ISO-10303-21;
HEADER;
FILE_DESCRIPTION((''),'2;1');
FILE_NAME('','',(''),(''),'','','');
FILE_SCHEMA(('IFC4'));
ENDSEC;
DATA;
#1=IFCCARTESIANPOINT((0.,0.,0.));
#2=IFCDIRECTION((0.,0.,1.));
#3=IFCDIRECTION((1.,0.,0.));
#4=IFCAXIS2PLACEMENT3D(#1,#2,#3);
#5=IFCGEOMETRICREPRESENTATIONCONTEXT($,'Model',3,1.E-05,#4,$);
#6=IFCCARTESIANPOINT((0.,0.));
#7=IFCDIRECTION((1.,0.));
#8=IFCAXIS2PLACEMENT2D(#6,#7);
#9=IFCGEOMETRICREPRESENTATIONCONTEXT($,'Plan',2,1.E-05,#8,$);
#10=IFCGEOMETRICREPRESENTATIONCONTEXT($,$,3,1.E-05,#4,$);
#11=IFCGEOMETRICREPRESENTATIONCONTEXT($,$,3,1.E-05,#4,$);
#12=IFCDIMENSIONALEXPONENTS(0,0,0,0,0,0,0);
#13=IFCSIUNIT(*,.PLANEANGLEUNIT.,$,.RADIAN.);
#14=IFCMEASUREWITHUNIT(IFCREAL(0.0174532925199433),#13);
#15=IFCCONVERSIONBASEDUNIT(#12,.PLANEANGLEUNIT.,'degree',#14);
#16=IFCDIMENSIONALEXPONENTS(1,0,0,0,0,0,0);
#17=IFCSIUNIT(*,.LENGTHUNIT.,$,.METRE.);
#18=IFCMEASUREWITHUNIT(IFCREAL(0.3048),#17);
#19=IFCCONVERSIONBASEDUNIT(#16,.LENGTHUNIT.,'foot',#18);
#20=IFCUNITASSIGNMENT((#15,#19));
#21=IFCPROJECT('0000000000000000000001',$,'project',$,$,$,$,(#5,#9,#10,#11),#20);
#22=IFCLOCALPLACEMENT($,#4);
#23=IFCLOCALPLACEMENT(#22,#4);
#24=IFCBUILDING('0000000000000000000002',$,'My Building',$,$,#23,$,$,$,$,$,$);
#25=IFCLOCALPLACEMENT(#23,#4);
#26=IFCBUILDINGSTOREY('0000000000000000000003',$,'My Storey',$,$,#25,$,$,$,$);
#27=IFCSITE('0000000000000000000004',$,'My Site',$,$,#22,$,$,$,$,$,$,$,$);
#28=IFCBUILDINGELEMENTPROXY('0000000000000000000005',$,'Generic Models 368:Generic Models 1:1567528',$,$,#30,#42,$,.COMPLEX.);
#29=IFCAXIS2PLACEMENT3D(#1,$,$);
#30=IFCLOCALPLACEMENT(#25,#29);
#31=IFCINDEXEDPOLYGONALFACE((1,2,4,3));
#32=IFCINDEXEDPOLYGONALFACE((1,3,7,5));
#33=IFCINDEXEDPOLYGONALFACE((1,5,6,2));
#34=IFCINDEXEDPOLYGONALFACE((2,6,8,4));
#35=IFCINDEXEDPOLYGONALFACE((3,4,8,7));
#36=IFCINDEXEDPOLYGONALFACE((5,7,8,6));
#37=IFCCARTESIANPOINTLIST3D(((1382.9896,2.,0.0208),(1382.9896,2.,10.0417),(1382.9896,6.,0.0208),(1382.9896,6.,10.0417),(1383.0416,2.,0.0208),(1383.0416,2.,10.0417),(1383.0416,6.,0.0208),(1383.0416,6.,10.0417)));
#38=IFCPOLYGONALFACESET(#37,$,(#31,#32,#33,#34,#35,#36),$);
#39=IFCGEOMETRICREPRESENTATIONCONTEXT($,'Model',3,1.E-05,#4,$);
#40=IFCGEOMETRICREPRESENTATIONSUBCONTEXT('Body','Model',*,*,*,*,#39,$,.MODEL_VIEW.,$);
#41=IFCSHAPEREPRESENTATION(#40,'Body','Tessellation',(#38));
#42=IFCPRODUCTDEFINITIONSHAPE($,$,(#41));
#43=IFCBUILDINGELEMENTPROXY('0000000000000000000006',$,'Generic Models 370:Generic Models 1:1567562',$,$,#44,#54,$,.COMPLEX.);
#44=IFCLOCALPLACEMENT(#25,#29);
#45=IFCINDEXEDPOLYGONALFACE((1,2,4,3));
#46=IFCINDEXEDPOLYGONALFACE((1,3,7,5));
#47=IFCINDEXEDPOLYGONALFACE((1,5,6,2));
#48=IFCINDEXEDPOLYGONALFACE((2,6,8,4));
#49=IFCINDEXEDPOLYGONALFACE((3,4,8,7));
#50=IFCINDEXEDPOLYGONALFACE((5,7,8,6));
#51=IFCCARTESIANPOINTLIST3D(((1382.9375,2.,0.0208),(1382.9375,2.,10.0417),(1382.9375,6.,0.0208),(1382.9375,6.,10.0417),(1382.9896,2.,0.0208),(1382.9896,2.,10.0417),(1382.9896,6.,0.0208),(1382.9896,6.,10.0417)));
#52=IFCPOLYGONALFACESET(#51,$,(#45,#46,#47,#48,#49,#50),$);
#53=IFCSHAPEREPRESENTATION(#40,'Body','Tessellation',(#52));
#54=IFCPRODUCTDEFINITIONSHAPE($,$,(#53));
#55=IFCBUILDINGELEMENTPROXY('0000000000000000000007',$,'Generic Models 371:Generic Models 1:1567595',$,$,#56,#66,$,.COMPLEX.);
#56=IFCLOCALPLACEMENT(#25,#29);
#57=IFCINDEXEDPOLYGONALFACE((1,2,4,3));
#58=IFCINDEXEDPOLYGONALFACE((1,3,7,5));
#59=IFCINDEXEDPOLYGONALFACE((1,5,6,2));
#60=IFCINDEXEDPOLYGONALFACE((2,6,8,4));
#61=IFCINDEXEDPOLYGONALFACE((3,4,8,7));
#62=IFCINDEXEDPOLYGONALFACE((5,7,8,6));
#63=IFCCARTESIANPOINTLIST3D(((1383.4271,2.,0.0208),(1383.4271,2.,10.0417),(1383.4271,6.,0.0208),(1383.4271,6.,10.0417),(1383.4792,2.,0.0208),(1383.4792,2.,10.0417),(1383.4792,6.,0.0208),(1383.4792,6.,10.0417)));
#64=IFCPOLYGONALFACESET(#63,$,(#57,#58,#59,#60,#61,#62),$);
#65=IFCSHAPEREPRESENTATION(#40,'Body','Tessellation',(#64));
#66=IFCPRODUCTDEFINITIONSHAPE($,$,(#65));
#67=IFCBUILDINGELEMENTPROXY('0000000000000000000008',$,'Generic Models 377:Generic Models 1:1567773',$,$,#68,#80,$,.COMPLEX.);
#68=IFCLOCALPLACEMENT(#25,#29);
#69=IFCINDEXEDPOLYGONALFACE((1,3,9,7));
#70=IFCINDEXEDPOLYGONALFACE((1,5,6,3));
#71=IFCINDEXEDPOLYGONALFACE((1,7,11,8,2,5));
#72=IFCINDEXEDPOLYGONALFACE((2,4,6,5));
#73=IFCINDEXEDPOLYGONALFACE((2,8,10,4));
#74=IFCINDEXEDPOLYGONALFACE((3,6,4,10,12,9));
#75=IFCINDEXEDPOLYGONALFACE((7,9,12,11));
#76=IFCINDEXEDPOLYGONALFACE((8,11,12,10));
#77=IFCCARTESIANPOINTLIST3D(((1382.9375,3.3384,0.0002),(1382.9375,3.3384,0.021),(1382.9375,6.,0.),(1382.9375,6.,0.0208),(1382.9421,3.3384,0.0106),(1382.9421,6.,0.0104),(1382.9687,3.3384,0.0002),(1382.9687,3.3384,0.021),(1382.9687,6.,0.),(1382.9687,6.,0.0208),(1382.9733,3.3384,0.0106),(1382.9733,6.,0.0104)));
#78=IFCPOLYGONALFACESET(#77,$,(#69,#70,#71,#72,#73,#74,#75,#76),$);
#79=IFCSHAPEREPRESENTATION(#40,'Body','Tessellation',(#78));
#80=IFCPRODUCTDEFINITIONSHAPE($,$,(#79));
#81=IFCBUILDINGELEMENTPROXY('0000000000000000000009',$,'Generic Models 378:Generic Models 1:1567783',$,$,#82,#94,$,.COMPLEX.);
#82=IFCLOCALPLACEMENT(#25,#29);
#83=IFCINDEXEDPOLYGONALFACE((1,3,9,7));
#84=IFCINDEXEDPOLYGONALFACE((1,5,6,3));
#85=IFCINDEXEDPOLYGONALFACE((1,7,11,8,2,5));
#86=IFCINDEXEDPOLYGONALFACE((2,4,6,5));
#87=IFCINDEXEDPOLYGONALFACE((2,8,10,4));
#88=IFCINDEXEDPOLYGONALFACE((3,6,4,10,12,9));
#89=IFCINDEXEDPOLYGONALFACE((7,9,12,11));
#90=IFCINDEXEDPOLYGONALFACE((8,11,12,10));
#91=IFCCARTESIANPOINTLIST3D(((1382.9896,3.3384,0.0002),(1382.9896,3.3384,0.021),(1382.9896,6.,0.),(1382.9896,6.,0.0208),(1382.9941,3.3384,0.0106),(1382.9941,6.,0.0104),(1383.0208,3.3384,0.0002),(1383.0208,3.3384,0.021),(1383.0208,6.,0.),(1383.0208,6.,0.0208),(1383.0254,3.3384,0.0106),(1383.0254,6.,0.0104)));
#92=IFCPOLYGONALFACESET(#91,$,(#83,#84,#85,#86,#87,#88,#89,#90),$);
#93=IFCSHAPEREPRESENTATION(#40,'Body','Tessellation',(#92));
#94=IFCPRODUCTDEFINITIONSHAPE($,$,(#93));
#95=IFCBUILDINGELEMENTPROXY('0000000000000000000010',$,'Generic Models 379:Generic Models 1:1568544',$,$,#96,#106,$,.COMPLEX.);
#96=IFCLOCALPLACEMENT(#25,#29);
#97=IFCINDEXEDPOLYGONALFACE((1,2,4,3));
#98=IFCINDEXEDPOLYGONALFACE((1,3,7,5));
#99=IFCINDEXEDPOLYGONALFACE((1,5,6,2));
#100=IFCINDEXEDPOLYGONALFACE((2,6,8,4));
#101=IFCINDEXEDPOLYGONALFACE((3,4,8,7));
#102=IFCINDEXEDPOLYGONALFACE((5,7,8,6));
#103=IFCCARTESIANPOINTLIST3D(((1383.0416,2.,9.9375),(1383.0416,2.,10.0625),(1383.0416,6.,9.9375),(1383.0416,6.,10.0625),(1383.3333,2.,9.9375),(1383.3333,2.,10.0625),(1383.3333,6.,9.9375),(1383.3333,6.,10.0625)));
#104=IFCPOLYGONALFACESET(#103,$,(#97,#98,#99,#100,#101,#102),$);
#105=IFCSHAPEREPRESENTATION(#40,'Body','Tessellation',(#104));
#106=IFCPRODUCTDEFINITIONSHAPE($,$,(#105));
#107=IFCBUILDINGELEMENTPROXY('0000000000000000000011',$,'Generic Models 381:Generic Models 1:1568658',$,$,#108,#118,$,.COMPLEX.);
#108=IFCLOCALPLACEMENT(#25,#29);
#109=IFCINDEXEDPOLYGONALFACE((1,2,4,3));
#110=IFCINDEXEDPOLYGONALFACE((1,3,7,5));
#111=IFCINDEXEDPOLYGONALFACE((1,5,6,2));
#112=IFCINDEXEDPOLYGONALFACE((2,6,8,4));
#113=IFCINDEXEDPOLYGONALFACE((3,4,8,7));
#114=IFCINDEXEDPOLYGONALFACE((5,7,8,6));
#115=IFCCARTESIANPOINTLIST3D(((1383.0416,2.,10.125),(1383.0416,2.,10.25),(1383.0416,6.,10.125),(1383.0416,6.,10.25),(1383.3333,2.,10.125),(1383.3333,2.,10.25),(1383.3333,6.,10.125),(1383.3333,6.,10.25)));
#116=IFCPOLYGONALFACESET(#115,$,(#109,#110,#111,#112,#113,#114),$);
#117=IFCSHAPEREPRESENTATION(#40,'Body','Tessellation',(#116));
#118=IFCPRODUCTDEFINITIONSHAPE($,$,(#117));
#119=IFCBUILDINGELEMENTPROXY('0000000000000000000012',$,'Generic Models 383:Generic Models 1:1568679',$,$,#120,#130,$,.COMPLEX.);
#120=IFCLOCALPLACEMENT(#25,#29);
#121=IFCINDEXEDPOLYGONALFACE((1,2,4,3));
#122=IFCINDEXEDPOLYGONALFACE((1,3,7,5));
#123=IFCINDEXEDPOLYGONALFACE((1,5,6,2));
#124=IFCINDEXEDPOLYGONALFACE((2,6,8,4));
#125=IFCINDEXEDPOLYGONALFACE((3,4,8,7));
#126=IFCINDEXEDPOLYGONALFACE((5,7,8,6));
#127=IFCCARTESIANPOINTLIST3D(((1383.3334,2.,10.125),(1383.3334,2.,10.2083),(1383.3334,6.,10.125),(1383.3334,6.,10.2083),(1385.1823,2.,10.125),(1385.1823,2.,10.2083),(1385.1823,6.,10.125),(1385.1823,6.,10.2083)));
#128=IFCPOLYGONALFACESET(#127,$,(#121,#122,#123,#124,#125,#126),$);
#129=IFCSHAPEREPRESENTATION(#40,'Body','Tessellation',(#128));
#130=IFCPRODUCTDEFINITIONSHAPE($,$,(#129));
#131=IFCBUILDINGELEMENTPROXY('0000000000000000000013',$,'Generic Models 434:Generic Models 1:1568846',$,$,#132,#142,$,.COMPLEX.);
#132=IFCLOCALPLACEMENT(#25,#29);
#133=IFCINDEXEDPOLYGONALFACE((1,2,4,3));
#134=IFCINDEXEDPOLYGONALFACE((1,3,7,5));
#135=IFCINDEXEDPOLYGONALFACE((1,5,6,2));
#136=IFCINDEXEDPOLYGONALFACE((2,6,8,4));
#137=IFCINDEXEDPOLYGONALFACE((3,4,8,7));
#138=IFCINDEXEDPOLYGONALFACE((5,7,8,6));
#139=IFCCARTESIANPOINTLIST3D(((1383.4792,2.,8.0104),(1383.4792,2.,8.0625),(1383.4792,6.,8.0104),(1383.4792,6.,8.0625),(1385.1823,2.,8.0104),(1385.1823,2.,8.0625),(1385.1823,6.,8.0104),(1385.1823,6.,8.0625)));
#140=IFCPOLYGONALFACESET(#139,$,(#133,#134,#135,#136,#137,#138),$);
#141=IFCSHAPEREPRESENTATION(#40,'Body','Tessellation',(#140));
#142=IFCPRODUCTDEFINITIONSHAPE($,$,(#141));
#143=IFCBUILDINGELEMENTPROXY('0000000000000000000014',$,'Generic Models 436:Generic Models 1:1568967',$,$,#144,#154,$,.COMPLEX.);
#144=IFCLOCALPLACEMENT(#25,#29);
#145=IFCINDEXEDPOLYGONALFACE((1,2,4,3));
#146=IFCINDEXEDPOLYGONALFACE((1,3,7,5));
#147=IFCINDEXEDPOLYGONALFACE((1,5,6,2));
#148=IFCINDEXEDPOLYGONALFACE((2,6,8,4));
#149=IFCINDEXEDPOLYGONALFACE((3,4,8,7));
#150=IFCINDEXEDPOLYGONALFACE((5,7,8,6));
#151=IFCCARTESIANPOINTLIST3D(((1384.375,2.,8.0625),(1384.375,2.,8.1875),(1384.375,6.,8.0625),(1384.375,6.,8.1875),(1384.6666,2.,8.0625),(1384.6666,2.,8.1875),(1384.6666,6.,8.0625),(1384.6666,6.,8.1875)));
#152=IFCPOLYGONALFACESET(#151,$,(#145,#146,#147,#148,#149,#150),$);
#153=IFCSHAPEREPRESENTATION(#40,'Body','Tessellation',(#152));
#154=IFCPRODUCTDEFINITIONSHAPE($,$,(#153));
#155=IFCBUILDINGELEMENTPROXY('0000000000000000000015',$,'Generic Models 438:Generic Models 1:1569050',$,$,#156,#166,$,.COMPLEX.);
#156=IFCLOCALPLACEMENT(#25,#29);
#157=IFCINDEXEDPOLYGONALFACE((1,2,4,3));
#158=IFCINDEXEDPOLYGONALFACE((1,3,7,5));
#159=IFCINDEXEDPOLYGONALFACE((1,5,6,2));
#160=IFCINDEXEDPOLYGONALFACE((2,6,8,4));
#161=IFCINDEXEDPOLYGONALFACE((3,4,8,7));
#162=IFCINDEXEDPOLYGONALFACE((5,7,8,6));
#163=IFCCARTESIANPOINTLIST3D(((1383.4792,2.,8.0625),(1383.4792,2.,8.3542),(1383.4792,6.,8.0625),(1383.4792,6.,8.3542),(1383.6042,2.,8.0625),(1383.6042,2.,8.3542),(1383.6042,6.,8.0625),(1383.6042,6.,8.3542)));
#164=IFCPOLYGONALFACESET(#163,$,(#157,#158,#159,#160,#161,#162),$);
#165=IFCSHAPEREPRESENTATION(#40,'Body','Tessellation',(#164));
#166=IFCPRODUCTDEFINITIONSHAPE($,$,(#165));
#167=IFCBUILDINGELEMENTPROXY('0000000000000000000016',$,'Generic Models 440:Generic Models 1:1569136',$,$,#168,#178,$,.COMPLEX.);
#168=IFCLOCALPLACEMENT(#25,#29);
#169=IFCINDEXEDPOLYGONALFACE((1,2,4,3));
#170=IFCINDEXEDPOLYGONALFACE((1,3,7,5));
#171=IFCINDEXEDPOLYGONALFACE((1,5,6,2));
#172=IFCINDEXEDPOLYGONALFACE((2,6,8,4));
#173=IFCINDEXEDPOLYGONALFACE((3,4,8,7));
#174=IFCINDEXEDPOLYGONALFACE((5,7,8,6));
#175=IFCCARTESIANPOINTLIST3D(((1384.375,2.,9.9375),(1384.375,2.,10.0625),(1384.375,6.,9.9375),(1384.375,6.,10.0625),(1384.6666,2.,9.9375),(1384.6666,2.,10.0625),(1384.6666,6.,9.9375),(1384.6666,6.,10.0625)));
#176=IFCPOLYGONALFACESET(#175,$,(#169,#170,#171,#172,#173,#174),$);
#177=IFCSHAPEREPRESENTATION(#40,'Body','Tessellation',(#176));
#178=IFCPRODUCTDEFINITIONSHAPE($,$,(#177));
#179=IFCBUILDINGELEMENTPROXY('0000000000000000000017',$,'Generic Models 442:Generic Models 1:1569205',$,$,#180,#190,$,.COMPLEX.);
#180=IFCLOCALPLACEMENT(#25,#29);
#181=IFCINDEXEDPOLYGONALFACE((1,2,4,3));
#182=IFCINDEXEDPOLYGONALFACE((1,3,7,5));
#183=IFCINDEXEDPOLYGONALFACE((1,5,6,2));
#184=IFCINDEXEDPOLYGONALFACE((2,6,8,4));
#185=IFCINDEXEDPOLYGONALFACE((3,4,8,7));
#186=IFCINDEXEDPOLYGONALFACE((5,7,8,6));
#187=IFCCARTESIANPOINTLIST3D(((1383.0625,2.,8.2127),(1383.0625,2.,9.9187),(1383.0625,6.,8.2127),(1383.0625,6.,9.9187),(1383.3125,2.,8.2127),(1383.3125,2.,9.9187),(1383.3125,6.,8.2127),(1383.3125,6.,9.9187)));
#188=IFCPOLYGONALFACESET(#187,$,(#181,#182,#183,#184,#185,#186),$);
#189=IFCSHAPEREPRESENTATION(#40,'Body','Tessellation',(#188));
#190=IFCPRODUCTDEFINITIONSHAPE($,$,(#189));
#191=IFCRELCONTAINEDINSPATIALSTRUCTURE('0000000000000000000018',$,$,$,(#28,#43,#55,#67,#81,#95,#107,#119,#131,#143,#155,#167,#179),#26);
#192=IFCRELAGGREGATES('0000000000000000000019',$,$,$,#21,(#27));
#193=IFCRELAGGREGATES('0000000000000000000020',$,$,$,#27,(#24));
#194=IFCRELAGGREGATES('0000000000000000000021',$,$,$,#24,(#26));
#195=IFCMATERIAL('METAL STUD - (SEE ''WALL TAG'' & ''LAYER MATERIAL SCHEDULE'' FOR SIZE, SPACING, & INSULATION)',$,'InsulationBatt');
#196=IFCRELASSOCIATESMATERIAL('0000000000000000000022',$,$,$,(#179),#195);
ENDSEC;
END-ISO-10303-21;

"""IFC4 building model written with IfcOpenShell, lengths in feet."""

from ifc_helpers import new_model, entity, si_unit, converted_unit, frame, origin_with_axes, origin_2d_with_axis, place, context, subcontext, project, spatial, polyline, outline, extrude, material, element, save


model = new_model("IFC4")

# Units and contexts
model_context_1 = context("Model", 3, precision=1e-05, world=origin_with_axes())
plan_context = context("Plan", 2, precision=1e-05, world=origin_2d_with_axis())
model_context_2 = context("Model", 3, precision=1e-05, world=origin_with_axes())
context_of_model_1 = context(None, 3, precision=1e-05, world=origin_with_axes())
context_of_model_2 = context(None, 3, precision=1e-05, world=origin_with_axes())
body_context = subcontext(model_context_2, "Body", "Model", "MODEL_VIEW")
ifc_project = project(units=[converted_unit("PLANEANGLEUNIT", "degree", entity("IfcReal", 0.0174532925199433), si_unit("PLANEANGLEUNIT", "RADIAN"), dimensions=[0, 0, 0, 0, 0, 0, 0]), converted_unit("LENGTHUNIT", "foot", entity("IfcReal", 0.3048), si_unit("LENGTHUNIT", "METRE"), dimensions=[1, 0, 0, 0, 0, 0, 0])], contexts=[model_context_1, plan_context, context_of_model_1, context_of_model_2])

# Site, building, storey
site_placement = place(None, origin_with_axes())
site = spatial("IfcSite", under=ifc_project, at=site_placement, Name="My Site")
building_placement = place(site_placement, origin_with_axes())
building = spatial("IfcBuilding", under=site, at=building_placement, Name="My Building")
storey_placement = place(building_placement, origin_with_axes())
storey = spatial("IfcBuildingStorey", under=building, at=storey_placement, Name="My Storey")

# Building element proxies
proxy_1_placement = place(storey_placement, frame((1382.9896, 6.0, 0.0208), z_axis=(0.0, -1.0, 0.0), x_axis=(0.0, 0.0, 1.0)))
element("IfcBuildingElementProxy", 1, at=proxy_1_placement, inside=storey, Name="Generic Models 368:Generic Models 1:1567528", PredefinedType="COMPLEX", context=body_context, shape_type="SweptSolid", body=[
    extrude(outline(polyline([(-5.0104, -0.026), (5.0104, -0.026), (5.0104, 0.026), (-5.0104, 0.026), (-5.0104, -0.026)])), frame((5.0104, -0.026, 0.0), z_axis=(0.0, 0.0, -1.0), x_axis=(-1.0, 0.0, 0.0)), (0.0, 0.0, -1.0), 4.0),
])
proxy_2_placement = place(storey_placement, frame((1382.9375, 6.0, 0.0208), z_axis=(0.0, -1.0, 0.0), x_axis=(0.0, 0.0, 1.0)))
element("IfcBuildingElementProxy", 2, at=proxy_2_placement, inside=storey, Name="Generic Models 370:Generic Models 1:1567562", PredefinedType="COMPLEX", context=body_context, shape_type="SweptSolid", body=[
    extrude(outline(polyline([(-5.0104, -0.026), (5.0104, -0.026), (5.0104, 0.026), (-5.0104, 0.026), (-5.0104, -0.026)])), frame((5.0104, -0.026, 0.0), z_axis=(0.0, 0.0, -1.0), x_axis=(1.0, 0.0, 0.0)), (0.0, 0.0, -1.0), 4.0),
])
proxy_3_placement = place(storey_placement, frame((1383.4271, 6.0, 0.0208), z_axis=(0.0, -1.0, 0.0), x_axis=(0.0, 0.0, 1.0)))
element("IfcBuildingElementProxy", 3, at=proxy_3_placement, inside=storey, Name="Generic Models 371:Generic Models 1:1567595", PredefinedType="COMPLEX", context=body_context, shape_type="SweptSolid", body=[
    extrude(outline(polyline([(-5.0104, -0.026), (5.0104, -0.026), (5.0104, 0.026), (-5.0104, 0.026), (-5.0104, -0.026)])), frame((5.0104, -0.026, 0.0), z_axis=(0.0, 0.0, -1.0), x_axis=(1.0, 0.0, 0.0)), (0.0, 0.0, -1.0), 4.0),
])
for number, where, z_axis, x_axis, name in (
    (4, (1382.9375, 6.0, 0.0), (0.0, -1.0, 0.0), (0.0, 0.0, 1.0), "Generic Models 377:Generic Models 1:1567773"),
    (5, (1382.9896, 6.0, 0.0), (0.0, -1.0, 0.0), (0.0, 0.0, 1.0), "Generic Models 378:Generic Models 1:1567783"),
):
    element("IfcBuildingElementProxy", number, at=place(storey_placement, frame(where, z_axis=z_axis, x_axis=x_axis)), inside=storey, Name=name, PredefinedType="COMPLEX", context=body_context, shape_type="SweptSolid", body=[
        extrude(outline(polyline([(0.0201, 0.0), (-0.0066, 0.0162), (-0.016, 0.0097), (-0.0175, -0.0016), (0.0093, -0.0178), (0.0107, -0.0065), (0.0201, 0.0)])), frame((0.0104, -0.0172, 0.0), z_axis=(0.0, 0.0, -1.0), x_axis=(0.51911, 0.854708, 0.0)), (0.000035, 0.000056, -1.0), 2.6616),
    ])
for number, where, z_axis, x_axis, name in (
    (6, (1383.0416, 6.0, 9.9375), (0.0, -1.0, 0.0), (0.0, 0.0, 1.0), "Generic Models 379:Generic Models 1:1568544"),
    (7, (1383.0416, 6.0, 10.125), (0.0, -1.0, 0.0), (0.0, 0.0, 1.0), "Generic Models 381:Generic Models 1:1568658"),
):
    element("IfcBuildingElementProxy", number, at=place(storey_placement, frame(where, z_axis=z_axis, x_axis=x_axis)), inside=storey, Name=name, PredefinedType="COMPLEX", context=body_context, shape_type="SweptSolid", body=[
        extrude(outline(polyline([(-0.1458, -0.0625), (0.1458, -0.0625), (0.1458, 0.0625), (-0.1458, 0.0625), (-0.1458, -0.0625)])), frame((0.0625, -0.1458, 0.0), z_axis=(0.0, 0.0, -1.0), x_axis=(0.0, 1.0, 0.0)), (0.0, 0.0, -1.0), 4.0),
    ])
proxy_4_placement = place(storey_placement, frame((1383.3334, 6.0, 10.125), z_axis=(0.0, -1.0, 0.0), x_axis=(0.0, 0.0, 1.0)))
element("IfcBuildingElementProxy", 8, at=proxy_4_placement, inside=storey, Name="Generic Models 383:Generic Models 1:1568679", PredefinedType="COMPLEX", context=body_context, shape_type="SweptSolid", body=[
    extrude(outline(polyline([(-0.0417, -0.9245), (0.0417, -0.9245), (0.0417, 0.9245), (-0.0417, 0.9245), (-0.0417, -0.9245)])), frame((0.0417, -0.9245, 0.0), z_axis=(0.0, 0.0, -1.0), x_axis=(-1.0, 0.0, 0.0)), (0.0, 0.0, -1.0), 4.0),
])
proxy_5_placement = place(storey_placement, frame((1383.4792, 6.0, 8.0104), z_axis=(0.0, -1.0, 0.0), x_axis=(0.0, 0.0, 1.0)))
element("IfcBuildingElementProxy", 9, at=proxy_5_placement, inside=storey, Name="Generic Models 434:Generic Models 1:1568846", PredefinedType="COMPLEX", context=body_context, shape_type="SweptSolid", body=[
    extrude(outline(polyline([(-0.026, -0.8516), (0.026, -0.8516), (0.026, 0.8516), (-0.026, 0.8516), (-0.026, -0.8516)])), frame((0.026, -0.8516, 0.0), z_axis=(0.0, 0.0, -1.0), x_axis=(-1.0, 0.0, 0.0)), (0.0, 0.0, -1.0), 4.0),
])
proxy_6_placement = place(storey_placement, frame((1384.375, 6.0, 8.0625), z_axis=(0.0, -1.0, 0.0), x_axis=(0.0, 0.0, 1.0)))
element("IfcBuildingElementProxy", 10, at=proxy_6_placement, inside=storey, Name="Generic Models 436:Generic Models 1:1568967", PredefinedType="COMPLEX", context=body_context, shape_type="SweptSolid", body=[
    extrude(outline(polyline([(-0.0625, -0.1458), (0.0625, -0.1458), (0.0625, 0.1458), (-0.0625, 0.1458), (-0.0625, -0.1458)])), frame((0.0625, -0.1458, 0.0), z_axis=(0.0, 0.0, -1.0), x_axis=(-1.0, 0.0, 0.0)), (0.0, 0.0, -1.0), 4.0),
])
proxy_7_placement = place(storey_placement, frame((1383.4792, 6.0, 8.0625), z_axis=(0.0, -1.0, 0.0), x_axis=(0.0, 0.0, 1.0)))
element("IfcBuildingElementProxy", 11, at=proxy_7_placement, inside=storey, Name="Generic Models 438:Generic Models 1:1569050", PredefinedType="COMPLEX", context=body_context, shape_type="SweptSolid", body=[
    extrude(outline(polyline([(-0.1458, -0.0625), (0.1458, -0.0625), (0.1458, 0.0625), (-0.1458, 0.0625), (-0.1458, -0.0625)])), frame((0.1458, -0.0625, 0.0), z_axis=(0.0, 0.0, -1.0), x_axis=(-1.0, 0.0, 0.0)), (0.0, 0.0, -1.0), 4.0),
])
proxy_8_placement = place(storey_placement, frame((1384.375, 6.0, 9.9375), z_axis=(0.0, -1.0, 0.0), x_axis=(0.0, 0.0, 1.0)))
element("IfcBuildingElementProxy", 12, at=proxy_8_placement, inside=storey, Name="Generic Models 440:Generic Models 1:1569136", PredefinedType="COMPLEX", context=body_context, shape_type="SweptSolid", body=[
    extrude(outline(polyline([(-0.1458, -0.0625), (0.1458, -0.0625), (0.1458, 0.0625), (-0.1458, 0.0625), (-0.1458, -0.0625)])), frame((0.0625, -0.1458, 0.0), z_axis=(0.0, 0.0, -1.0), x_axis=(0.0, 1.0, 0.0)), (0.0, 0.0, -1.0), 4.0),
])
ifc_material_1 = material(Name="METAL STUD - (SEE 'WALL TAG' & 'LAYER MATERIAL SCHEDULE' FOR SIZE, SPACING, & INSULATION)", Category="InsulationBatt")
proxy_9_placement = place(storey_placement, frame((1383.0625, 6.0, 8.2127), z_axis=(0.0, -1.0, 0.0), x_axis=(0.0, 0.0, 1.0)))
element("IfcBuildingElementProxy", 13, at=proxy_9_placement, inside=storey, material=ifc_material_1, Name="Generic Models 442:Generic Models 1:1569205", PredefinedType="COMPLEX", context=body_context, shape_type="SweptSolid", body=[
    extrude(outline(polyline([(-0.125, -0.853), (0.125, -0.853), (0.125, 0.853), (-0.125, 0.853), (-0.125, -0.853)])), frame((0.853, -0.125, 0.0), z_axis=(0.0, 0.0, -1.0), x_axis=(0.0, 1.0, 0.0)), (0.0, 0.0, -1.0), 4.0),
])

save(model, "model.ifc")
